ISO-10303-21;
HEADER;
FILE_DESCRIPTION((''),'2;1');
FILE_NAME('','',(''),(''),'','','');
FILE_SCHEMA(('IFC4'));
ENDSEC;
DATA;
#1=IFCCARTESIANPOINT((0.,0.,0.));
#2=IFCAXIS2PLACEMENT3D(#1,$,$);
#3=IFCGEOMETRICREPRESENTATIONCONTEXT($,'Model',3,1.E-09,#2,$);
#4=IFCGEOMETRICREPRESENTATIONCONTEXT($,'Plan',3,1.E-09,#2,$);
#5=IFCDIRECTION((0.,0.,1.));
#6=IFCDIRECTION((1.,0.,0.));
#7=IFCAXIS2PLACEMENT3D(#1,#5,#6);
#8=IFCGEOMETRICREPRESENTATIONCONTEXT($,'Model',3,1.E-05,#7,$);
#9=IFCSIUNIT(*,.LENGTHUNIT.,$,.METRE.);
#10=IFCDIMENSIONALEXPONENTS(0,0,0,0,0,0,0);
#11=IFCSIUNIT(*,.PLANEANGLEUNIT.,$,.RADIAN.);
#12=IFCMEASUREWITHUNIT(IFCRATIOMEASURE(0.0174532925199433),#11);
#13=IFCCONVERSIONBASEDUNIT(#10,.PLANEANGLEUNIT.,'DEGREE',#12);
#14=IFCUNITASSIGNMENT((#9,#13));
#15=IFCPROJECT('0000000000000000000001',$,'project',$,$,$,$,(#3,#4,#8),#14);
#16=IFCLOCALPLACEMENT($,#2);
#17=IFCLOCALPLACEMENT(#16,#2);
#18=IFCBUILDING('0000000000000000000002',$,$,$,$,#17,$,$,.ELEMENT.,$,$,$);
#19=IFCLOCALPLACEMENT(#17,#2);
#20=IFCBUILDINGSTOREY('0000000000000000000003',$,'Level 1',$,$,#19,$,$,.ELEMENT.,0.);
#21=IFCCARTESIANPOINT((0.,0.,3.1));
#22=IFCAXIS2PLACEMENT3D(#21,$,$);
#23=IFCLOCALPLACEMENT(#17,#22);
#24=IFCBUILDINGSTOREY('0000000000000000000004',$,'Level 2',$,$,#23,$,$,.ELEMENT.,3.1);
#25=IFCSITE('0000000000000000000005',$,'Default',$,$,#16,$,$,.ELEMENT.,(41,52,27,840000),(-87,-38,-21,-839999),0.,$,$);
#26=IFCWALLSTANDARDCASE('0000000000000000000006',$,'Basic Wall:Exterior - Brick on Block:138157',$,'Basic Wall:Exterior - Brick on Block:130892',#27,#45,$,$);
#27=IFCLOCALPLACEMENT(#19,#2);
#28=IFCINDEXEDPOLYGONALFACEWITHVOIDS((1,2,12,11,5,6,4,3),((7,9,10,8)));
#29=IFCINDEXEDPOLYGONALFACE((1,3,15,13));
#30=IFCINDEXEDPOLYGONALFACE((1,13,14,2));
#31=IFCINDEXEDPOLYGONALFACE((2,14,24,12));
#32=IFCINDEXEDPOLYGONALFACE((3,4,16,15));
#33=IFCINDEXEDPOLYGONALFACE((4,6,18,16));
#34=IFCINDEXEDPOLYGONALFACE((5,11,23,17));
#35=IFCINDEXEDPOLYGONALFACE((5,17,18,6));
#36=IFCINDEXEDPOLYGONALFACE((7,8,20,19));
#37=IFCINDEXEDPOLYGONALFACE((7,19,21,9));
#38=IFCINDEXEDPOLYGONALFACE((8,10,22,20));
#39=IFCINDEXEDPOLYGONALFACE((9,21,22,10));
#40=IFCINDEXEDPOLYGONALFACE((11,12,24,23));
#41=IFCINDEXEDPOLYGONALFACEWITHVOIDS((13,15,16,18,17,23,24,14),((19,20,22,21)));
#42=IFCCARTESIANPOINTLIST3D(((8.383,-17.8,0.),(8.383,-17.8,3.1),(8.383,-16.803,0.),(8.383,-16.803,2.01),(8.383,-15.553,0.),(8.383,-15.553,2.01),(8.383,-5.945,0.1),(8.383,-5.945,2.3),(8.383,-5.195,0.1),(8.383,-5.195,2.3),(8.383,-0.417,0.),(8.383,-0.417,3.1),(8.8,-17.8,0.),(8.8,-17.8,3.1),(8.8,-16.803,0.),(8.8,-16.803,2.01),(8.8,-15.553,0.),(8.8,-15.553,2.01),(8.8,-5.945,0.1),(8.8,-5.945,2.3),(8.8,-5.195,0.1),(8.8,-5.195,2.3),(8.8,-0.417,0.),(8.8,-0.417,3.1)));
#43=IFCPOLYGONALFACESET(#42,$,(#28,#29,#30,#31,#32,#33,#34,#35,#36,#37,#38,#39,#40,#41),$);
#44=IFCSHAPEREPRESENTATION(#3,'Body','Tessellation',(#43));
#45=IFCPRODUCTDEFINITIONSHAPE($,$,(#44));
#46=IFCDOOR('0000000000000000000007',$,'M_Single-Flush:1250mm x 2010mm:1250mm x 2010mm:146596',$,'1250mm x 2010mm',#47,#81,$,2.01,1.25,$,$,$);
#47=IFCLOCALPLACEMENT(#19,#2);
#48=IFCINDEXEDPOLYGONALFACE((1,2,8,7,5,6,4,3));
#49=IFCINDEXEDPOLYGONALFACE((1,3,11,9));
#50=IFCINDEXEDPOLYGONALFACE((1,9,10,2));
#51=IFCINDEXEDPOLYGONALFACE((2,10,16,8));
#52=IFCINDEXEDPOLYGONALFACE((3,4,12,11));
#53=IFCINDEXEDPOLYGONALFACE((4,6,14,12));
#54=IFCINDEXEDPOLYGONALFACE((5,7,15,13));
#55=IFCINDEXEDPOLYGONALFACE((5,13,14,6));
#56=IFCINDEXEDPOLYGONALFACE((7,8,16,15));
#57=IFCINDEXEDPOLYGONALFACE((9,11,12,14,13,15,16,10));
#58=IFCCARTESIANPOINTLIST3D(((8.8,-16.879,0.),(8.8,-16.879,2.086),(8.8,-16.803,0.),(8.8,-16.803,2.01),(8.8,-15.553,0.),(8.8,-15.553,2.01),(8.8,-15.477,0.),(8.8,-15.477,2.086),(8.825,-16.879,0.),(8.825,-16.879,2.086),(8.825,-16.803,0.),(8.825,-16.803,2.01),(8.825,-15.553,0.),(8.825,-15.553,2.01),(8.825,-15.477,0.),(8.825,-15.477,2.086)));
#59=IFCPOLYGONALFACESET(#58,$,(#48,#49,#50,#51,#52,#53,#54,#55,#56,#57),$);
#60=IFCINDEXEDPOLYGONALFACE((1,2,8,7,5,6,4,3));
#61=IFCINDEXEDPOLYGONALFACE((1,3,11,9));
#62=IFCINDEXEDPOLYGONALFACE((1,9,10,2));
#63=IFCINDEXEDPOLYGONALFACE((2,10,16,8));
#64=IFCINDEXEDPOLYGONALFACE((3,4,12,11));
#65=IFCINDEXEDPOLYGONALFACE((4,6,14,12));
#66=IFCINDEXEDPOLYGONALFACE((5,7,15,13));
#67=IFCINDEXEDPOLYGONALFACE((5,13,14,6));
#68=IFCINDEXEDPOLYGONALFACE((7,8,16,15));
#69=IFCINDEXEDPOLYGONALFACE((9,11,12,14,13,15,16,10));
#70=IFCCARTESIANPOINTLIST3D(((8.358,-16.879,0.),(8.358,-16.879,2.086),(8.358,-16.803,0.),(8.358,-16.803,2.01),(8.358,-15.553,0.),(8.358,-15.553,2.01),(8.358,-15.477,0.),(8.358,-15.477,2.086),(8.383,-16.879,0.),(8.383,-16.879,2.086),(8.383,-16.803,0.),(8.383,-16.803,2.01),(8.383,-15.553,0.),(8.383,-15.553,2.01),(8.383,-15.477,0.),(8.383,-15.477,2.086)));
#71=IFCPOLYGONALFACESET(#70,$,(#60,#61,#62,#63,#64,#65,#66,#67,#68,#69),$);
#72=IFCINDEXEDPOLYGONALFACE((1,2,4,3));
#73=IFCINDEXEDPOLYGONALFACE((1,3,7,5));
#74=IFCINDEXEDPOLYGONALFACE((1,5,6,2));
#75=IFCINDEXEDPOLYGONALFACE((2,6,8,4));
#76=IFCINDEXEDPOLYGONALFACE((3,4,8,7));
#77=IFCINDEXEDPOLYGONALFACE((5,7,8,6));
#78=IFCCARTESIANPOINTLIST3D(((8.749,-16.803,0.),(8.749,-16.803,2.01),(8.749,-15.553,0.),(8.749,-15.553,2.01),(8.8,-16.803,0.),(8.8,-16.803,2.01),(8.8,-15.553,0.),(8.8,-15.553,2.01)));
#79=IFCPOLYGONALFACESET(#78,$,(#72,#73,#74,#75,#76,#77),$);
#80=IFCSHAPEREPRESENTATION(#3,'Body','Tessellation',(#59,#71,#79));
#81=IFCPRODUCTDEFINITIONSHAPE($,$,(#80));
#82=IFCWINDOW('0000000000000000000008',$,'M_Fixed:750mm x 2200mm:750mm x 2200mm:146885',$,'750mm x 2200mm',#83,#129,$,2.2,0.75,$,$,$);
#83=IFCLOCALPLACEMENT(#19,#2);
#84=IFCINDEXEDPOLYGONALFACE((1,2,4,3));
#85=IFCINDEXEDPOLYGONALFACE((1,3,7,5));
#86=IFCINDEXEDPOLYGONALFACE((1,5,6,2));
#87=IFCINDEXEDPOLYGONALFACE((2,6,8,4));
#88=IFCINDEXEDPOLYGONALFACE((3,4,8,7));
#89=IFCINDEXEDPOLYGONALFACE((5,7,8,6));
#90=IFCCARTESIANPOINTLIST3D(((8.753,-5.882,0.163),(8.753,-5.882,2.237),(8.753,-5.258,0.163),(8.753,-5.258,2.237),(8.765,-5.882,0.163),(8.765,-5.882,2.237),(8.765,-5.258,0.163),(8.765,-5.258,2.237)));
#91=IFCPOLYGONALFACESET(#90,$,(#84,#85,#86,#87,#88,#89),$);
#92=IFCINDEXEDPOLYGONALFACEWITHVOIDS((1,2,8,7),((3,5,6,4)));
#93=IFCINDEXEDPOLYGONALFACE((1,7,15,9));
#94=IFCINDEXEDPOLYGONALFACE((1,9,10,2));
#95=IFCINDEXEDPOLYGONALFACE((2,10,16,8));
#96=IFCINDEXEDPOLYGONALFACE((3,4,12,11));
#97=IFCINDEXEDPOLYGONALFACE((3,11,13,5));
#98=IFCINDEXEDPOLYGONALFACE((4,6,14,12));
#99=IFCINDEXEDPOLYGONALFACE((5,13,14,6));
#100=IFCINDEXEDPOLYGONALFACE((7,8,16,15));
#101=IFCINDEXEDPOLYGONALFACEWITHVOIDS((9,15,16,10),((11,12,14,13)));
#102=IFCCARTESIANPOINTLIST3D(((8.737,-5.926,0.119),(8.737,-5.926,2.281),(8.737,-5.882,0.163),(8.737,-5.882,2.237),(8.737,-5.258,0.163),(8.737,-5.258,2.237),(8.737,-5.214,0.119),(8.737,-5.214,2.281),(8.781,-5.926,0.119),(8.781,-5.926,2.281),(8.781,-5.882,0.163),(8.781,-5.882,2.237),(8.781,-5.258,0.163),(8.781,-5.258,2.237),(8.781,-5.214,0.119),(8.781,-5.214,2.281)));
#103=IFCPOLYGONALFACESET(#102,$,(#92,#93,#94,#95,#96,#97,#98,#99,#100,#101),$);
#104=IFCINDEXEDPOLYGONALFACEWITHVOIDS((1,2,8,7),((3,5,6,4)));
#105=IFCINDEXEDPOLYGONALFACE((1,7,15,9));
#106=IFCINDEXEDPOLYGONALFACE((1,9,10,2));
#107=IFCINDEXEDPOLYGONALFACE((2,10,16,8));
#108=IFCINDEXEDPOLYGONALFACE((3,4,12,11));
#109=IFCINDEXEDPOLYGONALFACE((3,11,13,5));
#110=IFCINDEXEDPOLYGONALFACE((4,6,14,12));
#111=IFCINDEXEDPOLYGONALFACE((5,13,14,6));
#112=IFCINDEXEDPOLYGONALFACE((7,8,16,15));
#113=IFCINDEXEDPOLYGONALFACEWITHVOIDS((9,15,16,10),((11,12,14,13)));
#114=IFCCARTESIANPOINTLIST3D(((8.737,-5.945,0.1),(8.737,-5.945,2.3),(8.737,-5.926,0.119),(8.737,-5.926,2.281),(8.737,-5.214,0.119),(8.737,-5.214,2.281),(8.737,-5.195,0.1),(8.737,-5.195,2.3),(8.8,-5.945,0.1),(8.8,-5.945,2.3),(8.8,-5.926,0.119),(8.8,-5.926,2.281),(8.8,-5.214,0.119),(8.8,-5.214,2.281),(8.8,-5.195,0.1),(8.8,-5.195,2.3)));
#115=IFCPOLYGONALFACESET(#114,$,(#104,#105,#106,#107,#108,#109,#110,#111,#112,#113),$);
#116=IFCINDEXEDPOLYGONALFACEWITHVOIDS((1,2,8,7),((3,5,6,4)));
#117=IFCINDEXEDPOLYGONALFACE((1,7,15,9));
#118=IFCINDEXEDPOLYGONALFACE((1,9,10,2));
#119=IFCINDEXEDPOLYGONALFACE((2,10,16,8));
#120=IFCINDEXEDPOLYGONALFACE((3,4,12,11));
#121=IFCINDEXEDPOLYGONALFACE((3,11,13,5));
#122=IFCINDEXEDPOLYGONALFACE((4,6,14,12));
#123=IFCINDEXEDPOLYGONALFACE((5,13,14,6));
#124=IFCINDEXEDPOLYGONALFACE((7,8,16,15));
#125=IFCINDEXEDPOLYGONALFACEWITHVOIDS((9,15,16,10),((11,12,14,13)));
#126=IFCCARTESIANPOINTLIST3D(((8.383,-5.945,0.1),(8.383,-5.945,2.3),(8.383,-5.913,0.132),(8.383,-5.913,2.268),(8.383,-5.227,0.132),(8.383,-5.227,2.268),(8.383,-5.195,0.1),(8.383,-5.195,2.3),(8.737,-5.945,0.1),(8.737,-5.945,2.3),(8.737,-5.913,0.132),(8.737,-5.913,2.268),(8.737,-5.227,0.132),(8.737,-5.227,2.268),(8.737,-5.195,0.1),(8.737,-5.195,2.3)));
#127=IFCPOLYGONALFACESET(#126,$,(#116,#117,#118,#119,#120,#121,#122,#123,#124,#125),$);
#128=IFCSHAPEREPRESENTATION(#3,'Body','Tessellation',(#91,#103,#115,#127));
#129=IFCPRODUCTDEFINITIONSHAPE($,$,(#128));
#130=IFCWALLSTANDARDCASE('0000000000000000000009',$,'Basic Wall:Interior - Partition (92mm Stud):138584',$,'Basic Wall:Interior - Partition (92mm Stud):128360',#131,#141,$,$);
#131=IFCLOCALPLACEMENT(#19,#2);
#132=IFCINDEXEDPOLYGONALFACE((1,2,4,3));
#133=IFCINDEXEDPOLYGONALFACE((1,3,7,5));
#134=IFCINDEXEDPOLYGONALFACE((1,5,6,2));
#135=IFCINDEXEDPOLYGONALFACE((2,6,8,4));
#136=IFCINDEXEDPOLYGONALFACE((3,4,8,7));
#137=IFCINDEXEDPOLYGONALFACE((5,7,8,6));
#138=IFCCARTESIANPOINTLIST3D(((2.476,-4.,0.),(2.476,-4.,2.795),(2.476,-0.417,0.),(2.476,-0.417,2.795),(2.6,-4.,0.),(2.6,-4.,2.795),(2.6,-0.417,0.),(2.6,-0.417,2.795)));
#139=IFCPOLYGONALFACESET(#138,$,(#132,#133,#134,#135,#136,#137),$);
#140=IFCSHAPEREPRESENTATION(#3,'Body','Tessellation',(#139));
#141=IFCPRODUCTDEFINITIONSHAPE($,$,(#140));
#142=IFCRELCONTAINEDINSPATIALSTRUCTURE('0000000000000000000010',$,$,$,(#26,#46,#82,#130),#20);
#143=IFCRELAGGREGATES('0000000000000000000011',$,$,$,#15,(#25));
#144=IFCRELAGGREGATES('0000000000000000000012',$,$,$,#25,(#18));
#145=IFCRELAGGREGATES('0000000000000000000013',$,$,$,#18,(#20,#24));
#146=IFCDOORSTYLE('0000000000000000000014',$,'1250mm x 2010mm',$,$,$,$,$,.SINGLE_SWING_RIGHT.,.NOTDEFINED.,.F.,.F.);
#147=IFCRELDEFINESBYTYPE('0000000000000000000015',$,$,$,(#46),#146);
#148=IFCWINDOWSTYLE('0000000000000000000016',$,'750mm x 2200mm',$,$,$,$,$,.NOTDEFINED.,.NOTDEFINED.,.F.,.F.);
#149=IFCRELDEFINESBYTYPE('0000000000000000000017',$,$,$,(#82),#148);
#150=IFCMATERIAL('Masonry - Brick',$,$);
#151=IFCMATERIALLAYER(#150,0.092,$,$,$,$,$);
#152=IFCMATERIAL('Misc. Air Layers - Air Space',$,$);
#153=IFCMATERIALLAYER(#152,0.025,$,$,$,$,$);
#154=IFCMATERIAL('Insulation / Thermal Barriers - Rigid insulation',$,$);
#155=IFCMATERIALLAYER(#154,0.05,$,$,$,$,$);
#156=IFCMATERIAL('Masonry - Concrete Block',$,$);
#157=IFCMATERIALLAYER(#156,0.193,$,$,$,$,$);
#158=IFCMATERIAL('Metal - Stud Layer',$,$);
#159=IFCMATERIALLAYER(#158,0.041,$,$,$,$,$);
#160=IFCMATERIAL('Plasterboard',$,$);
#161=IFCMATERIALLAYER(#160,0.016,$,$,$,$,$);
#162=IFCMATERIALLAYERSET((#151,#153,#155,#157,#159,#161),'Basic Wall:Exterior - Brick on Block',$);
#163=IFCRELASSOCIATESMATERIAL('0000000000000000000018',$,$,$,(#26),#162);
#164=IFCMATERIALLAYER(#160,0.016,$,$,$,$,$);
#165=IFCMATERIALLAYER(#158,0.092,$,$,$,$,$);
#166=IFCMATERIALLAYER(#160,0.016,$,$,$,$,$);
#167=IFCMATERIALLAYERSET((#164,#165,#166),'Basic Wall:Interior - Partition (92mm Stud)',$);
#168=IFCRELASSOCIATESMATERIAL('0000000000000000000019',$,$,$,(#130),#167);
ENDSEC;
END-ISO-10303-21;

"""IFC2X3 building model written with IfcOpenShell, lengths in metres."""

from ifc_helpers import new_model, entity, si_unit, converted_unit, frame, frame_2d, origin, origin_with_axes, origin_2d_with_axis, place, context, project, spatial, polyline, rectangle, outline, extrude, source, transform, mapped, material, layer, layer_set, layer_usage, type_object, type_shapes, element, fill, save


model = new_model("IFC2X3")

# Units and contexts
model_context_1 = context("Model", 3, precision=1e-09, world=origin())
plan_context = context("Plan", 3, precision=1e-09, world=origin())
model_context_2 = context("Model", 3, precision=1e-05, world=origin_with_axes())
ifc_project = project(units=[si_unit("LENGTHUNIT", "METRE"), converted_unit("PLANEANGLEUNIT", "DEGREE", entity("IfcRatioMeasure", 0.0174532925199433), si_unit("PLANEANGLEUNIT", "RADIAN"), dimensions=[0, 0, 0, 0, 0, 0, 0])], contexts=[model_context_1, plan_context, model_context_2])

# Site, building, storey
site_placement = place(None, origin())
site = spatial("IfcSite", under=ifc_project, at=site_placement, Name="Default", CompositionType="ELEMENT", RefLatitude=(41, 52, 27, 840000), RefLongitude=(-87, -38, -21, -839999), RefElevation=0.0)
building_placement = place(site_placement, origin())
building = spatial("IfcBuilding", under=site, at=building_placement, CompositionType="ELEMENT")
storey_1_placement = place(building_placement, origin())
storey_1 = spatial("IfcBuildingStorey", under=building, at=storey_1_placement, Name="Level 1", CompositionType="ELEMENT", Elevation=0.0)

# Shared definitions
ifc_material_1 = material(Name="Masonry - Brick")
ifc_layer_1 = layer(ifc_material_1, 0.092)
ifc_material_2 = material(Name="Misc. Air Layers - Air Space")
ifc_layer_2 = layer(ifc_material_2, 0.025)
ifc_material_3 = material(Name="Insulation / Thermal Barriers - Rigid insulation")
ifc_layer_3 = layer(ifc_material_3, 0.05)
ifc_material_4 = material(Name="Masonry - Concrete Block")
ifc_layer_4 = layer(ifc_material_4, 0.193)
ifc_material_5 = material(Name="Metal - Stud Layer")
ifc_layer_5 = layer(ifc_material_5, 0.041)
ifc_material_6 = material(Name="Plasterboard")
ifc_layer_6 = layer(ifc_material_6, 0.016)
ifc_layer_set_1 = layer_set([ifc_layer_1, ifc_layer_2, ifc_layer_3, ifc_layer_4, ifc_layer_5, ifc_layer_6], Name="Basic Wall:Exterior - Brick on Block")

# Wall, openings, door, window
ifc_layer_usage_1 = layer_usage(ifc_layer_set_1, "AXIS2", "NEGATIVE", 0.2085)
wall_1_placement = place(storey_1_placement, frame((8.5915, -0.417, 0.0), z_axis=(0.0, 0.0, 1.0), x_axis=(0.0, -1.0, 0.0)))
wall_1 = element("IfcWallStandardCase", 1, at=wall_1_placement, inside=storey_1, material=ifc_layer_usage_1, Name="Basic Wall:Exterior - Brick on Block:138157", ObjectType="Basic Wall:Exterior - Brick on Block:130892", context=model_context_1, shape_type="SweptSolid", body=[
    extrude(rectangle(XDim=17.383, YDim=0.417, at=frame_2d((8.6915, 0.0), x_axis=(-1.0, 0.0))), origin(), (0.0, 0.0, 1.0), 3.1),
])
opening_1_placement = place(wall_1_placement, frame((15.136, -0.2085, 0.0)))
opening_1 = element("IfcOpeningElement", 2, at=opening_1_placement, cuts=wall_1, ObjectType="Opening", context=model_context_1, shape_type="SweptSolid", body=[
    extrude(rectangle(XDim=1.25, YDim=2.01, at=frame_2d((1.005, 0.625), x_axis=(0.0, 1.0))), frame((0.0, 0.0, 0.0), z_axis=(0.0, 1.0, 0.0), x_axis=(0.0, 0.0, 1.0)), (0.0, 0.0, 1.0), 0.417),
])
opening_2_placement = place(wall_1_placement, frame((4.778, -0.2085, 0.1)))
opening_2 = element("IfcOpeningElement", 3, at=opening_2_placement, cuts=wall_1, ObjectType="Opening", context=model_context_1, shape_type="SweptSolid", body=[
    extrude(rectangle(XDim=2.2, YDim=0.75, at=frame_2d((1.1, 0.375), x_axis=(1.0, 0.0))), frame((0.0, 0.0, 0.0), z_axis=(0.0, 1.0, 0.0), x_axis=(0.0, 0.0, 1.0)), (0.0, 0.0, 1.0), 0.417),
])
door_style_1 = type_object("IfcDoorStyle", Name="1250mm x 2010mm", ConstructionType="NOTDEFINED", OperationType="SINGLE_SWING_RIGHT", ParameterTakesPrecedence=False, Sizeable=False)
shared_shape_1 = source(origin(), model_context_1, "Body", "SweptSolid", [
    extrude(outline(polyline([(-0.701, -1.062), (0.701, -1.062), (0.701, 1.024), (0.625, 1.024), (0.625, -0.986), (-0.625, -0.986), (-0.625, 1.024), (-0.701, 1.024), (-0.701, -1.062)])), frame((0.625, 0.417, 1.024), z_axis=(0.0, 1.0, 0.0), x_axis=(1.0, 0.0, 0.0)), (0.0, 0.0, 1.0), 0.025),
    extrude(outline(polyline([(-1.062, -0.701), (1.024, -0.701), (1.024, -0.625), (-0.986, -0.625), (-0.986, 0.625), (1.024, 0.625), (1.024, 0.701), (-1.062, 0.701), (-1.062, -0.701)])), frame((0.625, -0.025, 1.024), z_axis=(0.0, 1.0, 0.0), x_axis=(0.0, 0.0, -1.0)), (0.0, 0.0, 1.0), 0.025),
    extrude(rectangle(XDim=0.051, YDim=1.25, at=origin_2d_with_axis()), frame((0.625, 0.3915, 0.0), z_axis=(0.0, 0.0, 1.0), x_axis=(0.0, 1.0, 0.0)), (0.0, 0.0, 1.0), 2.01),
])
type_shapes(door_style_1, [shared_shape_1])
door_1_placement = place(opening_1_placement, origin())
door_1 = element("IfcDoor", 4, at=door_1_placement, inside=storey_1, type_object=door_style_1, Name="M_Single-Flush:1250mm x 2010mm:1250mm x 2010mm:146596", ObjectType="1250mm x 2010mm", OverallHeight=2.01, OverallWidth=1.25, context=model_context_1, shape_type="MappedRepresentation", body=[
    mapped(shared_shape_1, transform((0.0, 0.0, 0.0), scale=1.0)),
])
fill(opening_1, door_1)
window_style_1 = type_object("IfcWindowStyle", Name="750mm x 2200mm", ConstructionType="NOTDEFINED", OperationType="NOTDEFINED", ParameterTakesPrecedence=False, Sizeable=False)
shared_shape_2 = source(origin(), model_context_1, "Body", "SweptSolid", [
    extrude(rectangle(XDim=0.012, YDim=0.624, at=origin_2d_with_axis()), frame((0.375, 0.376, 0.063), z_axis=(0.0, 0.0, 1.0), x_axis=(0.0, -1.0, 0.0)), (0.0, 0.0, 1.0), 2.074),
    extrude(outline(polyline([(-0.356, -1.081), (0.356, -1.081), (0.356, 1.081), (-0.356, 1.081), (-0.356, -1.081)]), holes=[polyline([(-0.312, -1.037), (-0.312, 1.037), (0.312, 1.037), (0.312, -1.037), (-0.312, -1.037)])]), frame((0.375, 0.354, 1.1), z_axis=(0.0, 1.0, 0.0), x_axis=(1.0, 0.0, 0.0)), (0.0, 0.0, 1.0), 0.044),
    extrude(outline(polyline([(-0.375, -1.1), (0.375, -1.1), (0.375, 1.1), (-0.375, 1.1), (-0.375, -1.1)]), holes=[polyline([(-0.356, -1.081), (-0.356, 1.081), (0.356, 1.081), (0.356, -1.081), (-0.356, -1.081)])]), frame((0.375, 0.354, 1.1), z_axis=(0.0, 1.0, 0.0), x_axis=(1.0, 0.0, 0.0)), (0.0, 0.0, 1.0), 0.063),
    extrude(outline(polyline([(-0.375, -1.1), (0.375, -1.1), (0.375, 1.1), (-0.375, 1.1), (-0.375, -1.1)]), holes=[polyline([(-0.343, -1.068), (-0.343, 1.068), (0.343, 1.068), (0.343, -1.068), (-0.343, -1.068)])]), frame((0.375, 0.0, 1.1), z_axis=(0.0, 1.0, 0.0), x_axis=(1.0, 0.0, 0.0)), (0.0, 0.0, 1.0), 0.354),
])
type_shapes(window_style_1, [shared_shape_2])
window_1_placement = place(opening_2_placement, origin())
window_1 = element("IfcWindow", 5, at=window_1_placement, inside=storey_1, type_object=window_style_1, Name="M_Fixed:750mm x 2200mm:750mm x 2200mm:146885", ObjectType="750mm x 2200mm", OverallHeight=2.2, OverallWidth=0.75, context=model_context_1, shape_type="MappedRepresentation", body=[
    mapped(shared_shape_2, transform((0.0, 0.0, 0.0), scale=1.0)),
])
fill(opening_2, window_1)

# Wall
ifc_layer_7 = layer(ifc_material_6, 0.016)
ifc_layer_8 = layer(ifc_material_5, 0.092)
ifc_layer_9 = layer(ifc_material_6, 0.016)
ifc_layer_set_2 = layer_set([ifc_layer_7, ifc_layer_8, ifc_layer_9], Name="Basic Wall:Interior - Partition (92mm Stud)")
ifc_layer_usage_2 = layer_usage(ifc_layer_set_2, "AXIS2", "NEGATIVE", 0.062)
wall_2_placement = place(storey_1_placement, frame((2.538, -0.417, 0.0), z_axis=(0.0, 0.0, 1.0), x_axis=(0.0, -1.0, 0.0)))
element("IfcWallStandardCase", 6, at=wall_2_placement, inside=storey_1, material=ifc_layer_usage_2, Name="Basic Wall:Interior - Partition (92mm Stud):138584", ObjectType="Basic Wall:Interior - Partition (92mm Stud):128360", context=model_context_1, shape_type="SweptSolid", body=[
    extrude(rectangle(XDim=3.583, YDim=0.124, at=frame_2d((1.7915, 0.0), x_axis=(-1.0, 0.0))), origin(), (0.0, 0.0, 1.0), 2.795),
])

# Shared definitions
storey_2_placement = place(building_placement, frame((0.0, 0.0, 3.1)))
storey_2 = spatial("IfcBuildingStorey", under=building, at=storey_2_placement, Name="Level 2", CompositionType="ELEMENT", Elevation=3.1)

save(model, "model.ifc")
